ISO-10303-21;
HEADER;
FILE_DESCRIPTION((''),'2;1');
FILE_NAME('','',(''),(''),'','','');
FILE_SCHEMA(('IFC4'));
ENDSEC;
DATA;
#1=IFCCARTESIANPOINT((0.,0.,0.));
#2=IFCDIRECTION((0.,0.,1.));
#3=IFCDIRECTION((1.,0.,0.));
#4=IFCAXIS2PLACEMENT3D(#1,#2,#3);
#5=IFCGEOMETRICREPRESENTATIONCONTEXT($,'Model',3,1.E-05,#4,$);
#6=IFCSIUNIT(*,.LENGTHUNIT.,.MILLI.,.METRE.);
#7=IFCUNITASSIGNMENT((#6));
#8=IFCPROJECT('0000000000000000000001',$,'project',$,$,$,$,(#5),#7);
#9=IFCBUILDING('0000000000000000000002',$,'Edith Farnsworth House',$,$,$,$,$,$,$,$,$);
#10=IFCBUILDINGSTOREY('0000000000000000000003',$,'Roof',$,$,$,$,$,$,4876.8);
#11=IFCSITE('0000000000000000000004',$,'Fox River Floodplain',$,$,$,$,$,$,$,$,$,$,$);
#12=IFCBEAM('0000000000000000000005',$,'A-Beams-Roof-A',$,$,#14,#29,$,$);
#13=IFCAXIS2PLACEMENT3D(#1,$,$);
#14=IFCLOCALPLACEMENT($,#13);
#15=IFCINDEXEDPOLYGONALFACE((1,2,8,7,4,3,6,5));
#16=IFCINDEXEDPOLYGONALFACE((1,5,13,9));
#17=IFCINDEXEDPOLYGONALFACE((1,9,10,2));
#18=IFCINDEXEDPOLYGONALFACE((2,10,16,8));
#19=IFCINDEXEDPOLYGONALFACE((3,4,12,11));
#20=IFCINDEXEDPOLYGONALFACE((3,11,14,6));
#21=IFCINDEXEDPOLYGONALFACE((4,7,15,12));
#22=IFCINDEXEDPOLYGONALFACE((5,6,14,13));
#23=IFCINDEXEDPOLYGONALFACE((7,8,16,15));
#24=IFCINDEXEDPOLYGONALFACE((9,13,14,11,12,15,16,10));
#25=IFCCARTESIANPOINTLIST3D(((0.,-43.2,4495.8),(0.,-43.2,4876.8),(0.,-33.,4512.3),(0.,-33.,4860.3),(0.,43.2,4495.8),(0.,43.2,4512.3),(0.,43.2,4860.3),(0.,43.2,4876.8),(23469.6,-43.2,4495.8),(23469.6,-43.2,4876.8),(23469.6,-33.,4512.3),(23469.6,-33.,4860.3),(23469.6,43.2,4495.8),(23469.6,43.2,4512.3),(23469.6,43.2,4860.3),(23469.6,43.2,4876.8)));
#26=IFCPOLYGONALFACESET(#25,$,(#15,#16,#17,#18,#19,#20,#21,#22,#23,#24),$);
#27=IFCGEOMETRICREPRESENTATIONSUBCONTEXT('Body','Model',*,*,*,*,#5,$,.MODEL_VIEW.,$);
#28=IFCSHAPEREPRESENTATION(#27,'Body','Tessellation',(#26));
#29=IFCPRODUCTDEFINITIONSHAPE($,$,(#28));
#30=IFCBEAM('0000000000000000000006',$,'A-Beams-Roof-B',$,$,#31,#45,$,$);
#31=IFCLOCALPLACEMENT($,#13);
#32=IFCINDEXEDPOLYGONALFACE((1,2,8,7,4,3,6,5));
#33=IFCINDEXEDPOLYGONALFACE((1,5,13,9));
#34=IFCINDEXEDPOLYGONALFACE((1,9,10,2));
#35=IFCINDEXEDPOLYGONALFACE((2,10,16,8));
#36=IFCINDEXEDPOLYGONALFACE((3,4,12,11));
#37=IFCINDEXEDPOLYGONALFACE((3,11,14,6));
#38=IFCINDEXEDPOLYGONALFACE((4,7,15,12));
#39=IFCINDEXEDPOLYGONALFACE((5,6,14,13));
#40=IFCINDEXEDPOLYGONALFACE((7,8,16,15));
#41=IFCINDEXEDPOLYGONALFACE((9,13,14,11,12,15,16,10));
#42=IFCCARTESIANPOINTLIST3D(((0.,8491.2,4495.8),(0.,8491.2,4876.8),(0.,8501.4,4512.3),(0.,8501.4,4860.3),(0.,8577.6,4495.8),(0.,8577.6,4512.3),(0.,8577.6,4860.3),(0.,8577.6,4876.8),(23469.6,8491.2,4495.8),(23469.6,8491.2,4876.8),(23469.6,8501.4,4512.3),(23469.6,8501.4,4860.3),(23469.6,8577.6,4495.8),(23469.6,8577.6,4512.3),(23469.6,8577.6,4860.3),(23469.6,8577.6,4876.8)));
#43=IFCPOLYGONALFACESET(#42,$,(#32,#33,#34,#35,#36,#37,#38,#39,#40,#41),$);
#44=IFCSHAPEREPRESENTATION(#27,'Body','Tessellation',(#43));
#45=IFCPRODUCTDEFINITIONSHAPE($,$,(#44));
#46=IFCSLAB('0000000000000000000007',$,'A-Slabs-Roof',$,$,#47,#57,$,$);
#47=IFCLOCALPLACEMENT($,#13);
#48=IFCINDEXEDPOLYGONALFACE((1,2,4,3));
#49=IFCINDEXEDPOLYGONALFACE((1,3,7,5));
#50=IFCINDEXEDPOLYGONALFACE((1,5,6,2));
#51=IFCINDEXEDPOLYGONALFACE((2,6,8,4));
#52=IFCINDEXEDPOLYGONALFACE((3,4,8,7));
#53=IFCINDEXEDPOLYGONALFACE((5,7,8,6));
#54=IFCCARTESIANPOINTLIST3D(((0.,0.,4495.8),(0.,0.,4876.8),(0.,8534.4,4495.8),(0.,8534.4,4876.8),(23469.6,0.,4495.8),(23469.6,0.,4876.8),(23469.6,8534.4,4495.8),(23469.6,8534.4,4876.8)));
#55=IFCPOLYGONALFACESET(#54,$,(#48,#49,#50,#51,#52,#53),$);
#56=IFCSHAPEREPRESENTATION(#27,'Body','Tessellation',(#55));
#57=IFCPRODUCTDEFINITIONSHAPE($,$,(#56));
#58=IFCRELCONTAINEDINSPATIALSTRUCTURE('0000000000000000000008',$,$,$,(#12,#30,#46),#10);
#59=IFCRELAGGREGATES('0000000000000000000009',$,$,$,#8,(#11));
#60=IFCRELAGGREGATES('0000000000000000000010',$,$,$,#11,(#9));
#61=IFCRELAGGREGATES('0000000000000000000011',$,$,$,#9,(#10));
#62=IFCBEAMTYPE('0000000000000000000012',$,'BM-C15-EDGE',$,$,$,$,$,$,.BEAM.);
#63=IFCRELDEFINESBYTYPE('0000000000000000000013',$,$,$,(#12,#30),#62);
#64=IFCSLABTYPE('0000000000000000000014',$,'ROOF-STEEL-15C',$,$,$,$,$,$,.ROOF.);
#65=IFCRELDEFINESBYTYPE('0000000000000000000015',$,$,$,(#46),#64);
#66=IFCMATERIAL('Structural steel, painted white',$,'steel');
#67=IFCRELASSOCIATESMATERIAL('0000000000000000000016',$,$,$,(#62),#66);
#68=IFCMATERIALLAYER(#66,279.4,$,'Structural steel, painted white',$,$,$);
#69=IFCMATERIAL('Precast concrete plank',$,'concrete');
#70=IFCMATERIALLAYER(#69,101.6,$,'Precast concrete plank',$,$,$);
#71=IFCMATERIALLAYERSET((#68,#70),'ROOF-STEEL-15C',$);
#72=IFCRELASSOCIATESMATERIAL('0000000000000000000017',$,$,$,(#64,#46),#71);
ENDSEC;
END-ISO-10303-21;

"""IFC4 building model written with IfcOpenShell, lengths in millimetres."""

from ifc_helpers import new_model, si_unit, frame, origin, origin_with_axes, place, context, subcontext, project, spatial, indexed_curve, u_section, outline, extrude, material, layer, layer_set, layer_usage, type_object, element, save


model = new_model("IFC4")

# Units and contexts
model_context = context("Model", 3, precision=1e-05, world=origin_with_axes())
body_context = subcontext(model_context, "Body", "Model", "MODEL_VIEW")
ifc_project = project(units=[si_unit("LENGTHUNIT", "METRE", prefix="MILLI")], contexts=[model_context])

# Site, building, storey
site = spatial("IfcSite", under=ifc_project, Name="Fox River Floodplain")
building = spatial("IfcBuilding", under=site, Name="Edith Farnsworth House")
storey = spatial("IfcBuildingStorey", under=building, Name="Roof", Elevation=4876.8)

# Beams
ifc_material_1 = material(Name="Structural steel, painted white", Category="steel")
beam_type = type_object("IfcBeamType", Name="BM-C15-EDGE", PredefinedType="BEAM", material=ifc_material_1)
for number, where, z_axis, x_axis, name in (
    (1, (0.0, 0.0, 4686.3), (1.0, 0.0, 0.0), (0.0, 1.0, 0.0), "A-Beams-Roof-A"),
    (2, (0.0, 8534.4, 4686.3), (1.0, 0.0, 0.0), (0.0, 1.0, 0.0), "A-Beams-Roof-B"),
):
    element("IfcBeam", number, at=place(None, frame(where, z_axis=z_axis, x_axis=x_axis)), inside=storey, type_object=beam_type, Name=name, context=body_context, shape_type="SweptSolid", body=[
        extrude(u_section(Depth=381.0, FlangeWidth=86.4, WebThickness=10.2, FlangeThickness=16.5), origin(), (0.0, 0.0, 1.0), 23469.6),
    ])

# Slab
ifc_layer_1 = layer(ifc_material_1, 279.4, Name="Structural steel, painted white")
ifc_material_2 = material(Name="Precast concrete plank", Category="concrete")
ifc_layer_2 = layer(ifc_material_2, 101.6, Name="Precast concrete plank")
ifc_layer_set = layer_set([ifc_layer_1, ifc_layer_2], Name="ROOF-STEEL-15C")
ifc_layer_usage = layer_usage(ifc_layer_set, "AXIS3", "POSITIVE", 0.0)
slab_type = type_object("IfcSlabType", Name="ROOF-STEEL-15C", PredefinedType="ROOF", material=ifc_layer_set)
slab_placement = place(None, frame((0.0, 0.0, 4495.8), z_axis=(0.0, 0.0, 1.0), x_axis=(1.0, 0.0, 0.0)))
element("IfcSlab", 3, at=slab_placement, inside=storey, type_object=slab_type, material=ifc_layer_usage, Name="A-Slabs-Roof", context=body_context, shape_type="SweptSolid", body=[
    extrude(outline(indexed_curve([(0.0, 0.0), (23469.6, 0.0), (23469.6, 8534.4), (0.0, 8534.4)])), None, (0.0, 0.0, 1.0), 381.0),
])

save(model, "model.ifc")
